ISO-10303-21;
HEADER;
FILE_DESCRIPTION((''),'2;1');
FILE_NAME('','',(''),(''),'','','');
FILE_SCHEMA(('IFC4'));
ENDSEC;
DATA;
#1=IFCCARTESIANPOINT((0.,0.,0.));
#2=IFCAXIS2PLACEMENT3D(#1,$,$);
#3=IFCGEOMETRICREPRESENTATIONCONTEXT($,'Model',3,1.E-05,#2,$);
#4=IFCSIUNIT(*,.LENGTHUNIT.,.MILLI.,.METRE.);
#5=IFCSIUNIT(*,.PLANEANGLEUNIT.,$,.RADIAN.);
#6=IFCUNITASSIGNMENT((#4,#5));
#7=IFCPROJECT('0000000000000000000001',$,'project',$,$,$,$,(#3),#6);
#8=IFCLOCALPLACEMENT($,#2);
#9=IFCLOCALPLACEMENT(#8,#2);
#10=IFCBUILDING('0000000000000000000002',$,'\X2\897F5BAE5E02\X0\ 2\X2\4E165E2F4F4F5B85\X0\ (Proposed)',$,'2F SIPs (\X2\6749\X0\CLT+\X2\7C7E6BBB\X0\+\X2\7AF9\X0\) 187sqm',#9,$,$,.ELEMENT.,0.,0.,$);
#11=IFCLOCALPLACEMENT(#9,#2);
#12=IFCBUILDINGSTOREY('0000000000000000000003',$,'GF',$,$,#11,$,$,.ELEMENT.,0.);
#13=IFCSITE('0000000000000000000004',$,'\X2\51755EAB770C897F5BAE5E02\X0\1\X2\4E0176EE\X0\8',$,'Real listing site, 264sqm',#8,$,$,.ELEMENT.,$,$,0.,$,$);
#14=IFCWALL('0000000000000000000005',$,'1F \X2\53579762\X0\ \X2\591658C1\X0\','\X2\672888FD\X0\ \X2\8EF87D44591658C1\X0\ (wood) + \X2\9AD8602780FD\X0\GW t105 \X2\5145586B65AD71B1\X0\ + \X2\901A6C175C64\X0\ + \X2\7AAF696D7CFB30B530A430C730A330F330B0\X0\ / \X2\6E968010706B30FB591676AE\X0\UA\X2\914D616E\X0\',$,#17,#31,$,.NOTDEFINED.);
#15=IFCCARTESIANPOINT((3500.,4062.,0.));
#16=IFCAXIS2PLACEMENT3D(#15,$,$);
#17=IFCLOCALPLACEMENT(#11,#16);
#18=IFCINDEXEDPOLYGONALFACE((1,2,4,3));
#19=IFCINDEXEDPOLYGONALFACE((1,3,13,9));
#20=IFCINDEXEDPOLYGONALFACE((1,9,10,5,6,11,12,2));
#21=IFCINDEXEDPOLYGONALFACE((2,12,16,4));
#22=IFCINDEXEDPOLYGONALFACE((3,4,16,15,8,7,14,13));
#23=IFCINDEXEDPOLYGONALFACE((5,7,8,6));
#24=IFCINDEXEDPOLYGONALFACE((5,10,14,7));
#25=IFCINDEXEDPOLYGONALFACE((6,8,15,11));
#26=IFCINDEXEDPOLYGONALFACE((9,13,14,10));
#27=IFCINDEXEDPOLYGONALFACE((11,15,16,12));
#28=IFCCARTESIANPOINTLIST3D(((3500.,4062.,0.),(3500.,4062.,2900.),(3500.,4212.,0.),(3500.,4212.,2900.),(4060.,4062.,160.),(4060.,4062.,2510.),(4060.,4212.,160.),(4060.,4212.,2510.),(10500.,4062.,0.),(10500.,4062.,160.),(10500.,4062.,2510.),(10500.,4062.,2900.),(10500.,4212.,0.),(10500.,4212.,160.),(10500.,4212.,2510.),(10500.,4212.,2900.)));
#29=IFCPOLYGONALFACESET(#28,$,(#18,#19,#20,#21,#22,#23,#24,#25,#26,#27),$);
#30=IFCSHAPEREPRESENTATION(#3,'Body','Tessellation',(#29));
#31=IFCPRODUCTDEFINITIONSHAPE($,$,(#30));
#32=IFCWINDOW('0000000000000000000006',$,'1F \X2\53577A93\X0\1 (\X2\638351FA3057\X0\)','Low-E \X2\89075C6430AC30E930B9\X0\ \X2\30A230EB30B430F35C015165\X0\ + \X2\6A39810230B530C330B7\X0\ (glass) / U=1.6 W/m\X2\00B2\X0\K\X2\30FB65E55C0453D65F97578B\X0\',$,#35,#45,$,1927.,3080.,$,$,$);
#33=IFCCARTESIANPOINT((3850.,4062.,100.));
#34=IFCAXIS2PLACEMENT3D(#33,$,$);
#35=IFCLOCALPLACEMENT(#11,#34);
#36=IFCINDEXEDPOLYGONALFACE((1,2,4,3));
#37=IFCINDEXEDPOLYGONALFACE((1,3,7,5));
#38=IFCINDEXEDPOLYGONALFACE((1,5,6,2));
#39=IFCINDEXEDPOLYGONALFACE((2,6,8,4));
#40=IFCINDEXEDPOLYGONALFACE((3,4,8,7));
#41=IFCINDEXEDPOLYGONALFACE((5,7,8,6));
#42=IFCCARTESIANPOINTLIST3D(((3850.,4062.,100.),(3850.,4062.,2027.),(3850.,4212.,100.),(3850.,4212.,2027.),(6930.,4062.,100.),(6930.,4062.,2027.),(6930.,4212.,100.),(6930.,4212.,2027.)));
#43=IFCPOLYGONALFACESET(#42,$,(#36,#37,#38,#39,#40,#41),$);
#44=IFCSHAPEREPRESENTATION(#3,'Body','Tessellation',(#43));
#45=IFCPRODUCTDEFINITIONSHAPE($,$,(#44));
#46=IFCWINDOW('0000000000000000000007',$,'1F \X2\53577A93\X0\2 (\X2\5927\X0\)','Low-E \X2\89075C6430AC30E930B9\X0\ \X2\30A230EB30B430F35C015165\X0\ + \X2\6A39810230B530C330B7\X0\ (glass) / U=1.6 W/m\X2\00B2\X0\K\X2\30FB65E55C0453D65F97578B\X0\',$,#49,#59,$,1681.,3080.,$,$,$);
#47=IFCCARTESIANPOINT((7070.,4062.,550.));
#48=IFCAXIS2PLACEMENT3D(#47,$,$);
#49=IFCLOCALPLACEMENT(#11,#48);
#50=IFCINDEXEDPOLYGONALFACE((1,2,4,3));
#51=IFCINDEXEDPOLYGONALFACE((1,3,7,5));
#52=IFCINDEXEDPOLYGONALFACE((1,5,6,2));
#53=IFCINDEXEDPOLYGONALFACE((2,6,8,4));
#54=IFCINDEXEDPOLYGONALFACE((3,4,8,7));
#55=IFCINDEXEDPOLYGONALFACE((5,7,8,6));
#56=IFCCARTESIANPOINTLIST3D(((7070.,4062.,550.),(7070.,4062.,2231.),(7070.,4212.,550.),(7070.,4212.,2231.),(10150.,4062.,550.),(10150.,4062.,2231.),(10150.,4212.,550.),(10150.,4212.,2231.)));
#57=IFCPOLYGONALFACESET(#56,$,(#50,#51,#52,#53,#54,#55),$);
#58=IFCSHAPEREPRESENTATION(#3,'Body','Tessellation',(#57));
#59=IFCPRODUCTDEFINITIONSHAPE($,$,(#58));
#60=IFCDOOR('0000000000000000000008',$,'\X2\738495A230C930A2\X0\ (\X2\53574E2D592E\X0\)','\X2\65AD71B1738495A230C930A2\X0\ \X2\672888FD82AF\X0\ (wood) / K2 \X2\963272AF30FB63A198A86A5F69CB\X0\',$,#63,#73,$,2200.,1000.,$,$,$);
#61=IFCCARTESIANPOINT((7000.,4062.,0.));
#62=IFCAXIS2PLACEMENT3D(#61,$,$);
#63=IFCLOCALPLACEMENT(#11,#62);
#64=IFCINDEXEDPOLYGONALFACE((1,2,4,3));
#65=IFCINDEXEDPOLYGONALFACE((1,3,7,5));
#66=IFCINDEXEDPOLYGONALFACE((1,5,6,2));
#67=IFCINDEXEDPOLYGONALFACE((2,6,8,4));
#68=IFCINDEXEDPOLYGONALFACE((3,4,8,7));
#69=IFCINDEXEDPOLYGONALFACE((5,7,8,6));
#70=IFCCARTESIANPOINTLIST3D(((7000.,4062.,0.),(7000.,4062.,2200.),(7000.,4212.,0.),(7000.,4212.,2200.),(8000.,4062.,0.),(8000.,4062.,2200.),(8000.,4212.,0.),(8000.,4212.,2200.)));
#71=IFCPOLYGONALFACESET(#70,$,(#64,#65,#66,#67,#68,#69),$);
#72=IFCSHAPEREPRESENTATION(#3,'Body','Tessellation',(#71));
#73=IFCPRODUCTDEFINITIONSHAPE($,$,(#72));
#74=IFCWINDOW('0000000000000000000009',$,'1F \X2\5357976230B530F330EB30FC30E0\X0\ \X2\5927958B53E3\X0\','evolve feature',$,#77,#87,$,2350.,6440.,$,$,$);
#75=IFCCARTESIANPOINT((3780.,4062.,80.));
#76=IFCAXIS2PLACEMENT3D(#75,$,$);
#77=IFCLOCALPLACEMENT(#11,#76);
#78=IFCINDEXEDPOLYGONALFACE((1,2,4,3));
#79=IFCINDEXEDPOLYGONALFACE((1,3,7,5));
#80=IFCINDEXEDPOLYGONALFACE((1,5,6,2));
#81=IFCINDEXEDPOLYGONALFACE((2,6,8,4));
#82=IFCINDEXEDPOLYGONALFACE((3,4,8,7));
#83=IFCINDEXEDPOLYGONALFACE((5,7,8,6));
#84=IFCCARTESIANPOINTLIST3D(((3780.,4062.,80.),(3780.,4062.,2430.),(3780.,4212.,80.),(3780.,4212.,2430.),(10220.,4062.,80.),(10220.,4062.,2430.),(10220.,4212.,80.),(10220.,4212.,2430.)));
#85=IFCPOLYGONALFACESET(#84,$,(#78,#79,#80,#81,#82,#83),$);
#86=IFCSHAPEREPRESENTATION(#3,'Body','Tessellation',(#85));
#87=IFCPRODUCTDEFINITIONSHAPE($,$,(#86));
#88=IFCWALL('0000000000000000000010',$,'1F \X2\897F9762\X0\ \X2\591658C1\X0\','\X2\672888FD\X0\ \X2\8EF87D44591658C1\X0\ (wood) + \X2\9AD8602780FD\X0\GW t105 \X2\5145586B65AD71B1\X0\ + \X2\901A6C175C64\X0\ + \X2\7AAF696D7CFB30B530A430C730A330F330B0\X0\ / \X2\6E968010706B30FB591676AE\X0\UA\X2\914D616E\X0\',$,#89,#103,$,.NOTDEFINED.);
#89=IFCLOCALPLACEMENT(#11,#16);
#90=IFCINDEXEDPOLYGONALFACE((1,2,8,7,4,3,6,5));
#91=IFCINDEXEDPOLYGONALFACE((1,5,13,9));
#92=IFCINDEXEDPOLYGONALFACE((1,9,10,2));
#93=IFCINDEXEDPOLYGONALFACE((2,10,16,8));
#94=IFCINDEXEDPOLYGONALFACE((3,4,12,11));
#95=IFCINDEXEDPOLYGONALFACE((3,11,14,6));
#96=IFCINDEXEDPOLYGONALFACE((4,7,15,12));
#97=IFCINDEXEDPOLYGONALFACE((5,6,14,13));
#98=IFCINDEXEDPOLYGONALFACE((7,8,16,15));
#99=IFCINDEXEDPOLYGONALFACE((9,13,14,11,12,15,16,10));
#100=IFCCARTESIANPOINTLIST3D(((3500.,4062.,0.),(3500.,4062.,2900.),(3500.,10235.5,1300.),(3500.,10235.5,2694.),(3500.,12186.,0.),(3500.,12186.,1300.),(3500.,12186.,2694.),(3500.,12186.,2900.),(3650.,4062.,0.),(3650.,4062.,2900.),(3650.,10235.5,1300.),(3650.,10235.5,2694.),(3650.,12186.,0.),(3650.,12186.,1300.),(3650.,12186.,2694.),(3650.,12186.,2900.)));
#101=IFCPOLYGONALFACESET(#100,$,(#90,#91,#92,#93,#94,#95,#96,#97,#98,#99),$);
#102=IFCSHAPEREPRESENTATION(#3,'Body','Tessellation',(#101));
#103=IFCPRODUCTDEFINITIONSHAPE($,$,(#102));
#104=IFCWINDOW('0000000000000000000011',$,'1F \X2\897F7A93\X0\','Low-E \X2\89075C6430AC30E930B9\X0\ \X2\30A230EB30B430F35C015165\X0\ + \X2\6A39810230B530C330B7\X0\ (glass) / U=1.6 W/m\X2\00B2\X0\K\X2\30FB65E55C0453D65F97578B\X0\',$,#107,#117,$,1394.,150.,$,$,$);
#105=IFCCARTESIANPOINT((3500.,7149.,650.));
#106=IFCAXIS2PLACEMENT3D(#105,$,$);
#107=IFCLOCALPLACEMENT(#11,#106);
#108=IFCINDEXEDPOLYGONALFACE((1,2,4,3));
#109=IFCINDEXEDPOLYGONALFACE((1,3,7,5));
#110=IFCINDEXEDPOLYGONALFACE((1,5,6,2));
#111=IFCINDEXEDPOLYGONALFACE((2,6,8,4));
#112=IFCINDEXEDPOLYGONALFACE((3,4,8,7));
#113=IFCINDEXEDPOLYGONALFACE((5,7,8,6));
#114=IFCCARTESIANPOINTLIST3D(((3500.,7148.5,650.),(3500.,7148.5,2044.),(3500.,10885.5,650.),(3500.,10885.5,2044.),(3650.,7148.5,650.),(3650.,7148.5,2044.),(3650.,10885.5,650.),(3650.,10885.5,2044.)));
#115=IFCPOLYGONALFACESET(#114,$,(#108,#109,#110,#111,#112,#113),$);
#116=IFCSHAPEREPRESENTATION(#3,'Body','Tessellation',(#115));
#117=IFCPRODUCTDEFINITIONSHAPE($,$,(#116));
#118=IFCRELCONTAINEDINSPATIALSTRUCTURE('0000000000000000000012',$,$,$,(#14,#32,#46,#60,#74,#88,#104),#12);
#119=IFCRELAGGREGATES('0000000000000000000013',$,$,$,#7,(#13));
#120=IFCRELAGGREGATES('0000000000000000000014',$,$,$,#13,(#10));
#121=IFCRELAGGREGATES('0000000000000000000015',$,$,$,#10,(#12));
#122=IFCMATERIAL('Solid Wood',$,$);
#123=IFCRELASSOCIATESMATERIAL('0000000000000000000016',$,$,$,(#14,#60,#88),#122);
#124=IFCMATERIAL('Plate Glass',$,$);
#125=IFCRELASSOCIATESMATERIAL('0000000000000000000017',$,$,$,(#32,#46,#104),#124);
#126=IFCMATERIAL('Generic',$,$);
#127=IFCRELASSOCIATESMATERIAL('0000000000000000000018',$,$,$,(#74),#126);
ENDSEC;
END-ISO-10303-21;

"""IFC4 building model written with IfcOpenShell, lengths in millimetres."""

from ifc_helpers import new_model, si_unit, frame, frame_2d, origin, place, context, project, spatial, rectangle, extrude, material, element, fill, save


model = new_model("IFC4")

# Units and contexts
model_context = context("Model", 3, precision=1e-05, world=origin())
ifc_project = project(units=[si_unit("LENGTHUNIT", "METRE", prefix="MILLI"), si_unit("PLANEANGLEUNIT", "RADIAN")], contexts=[model_context])

# Site, building, storey
site_placement = place(None, origin())
site = spatial("IfcSite", under=ifc_project, at=site_placement, Name="兵庫県西宮市1丁目8", ObjectType="Real listing site, 264sqm", CompositionType="ELEMENT", RefElevation=0.0)
building_placement = place(site_placement, origin())
building = spatial("IfcBuilding", under=site, at=building_placement, Name="西宮市 2世帯住宅 (Proposed)", ObjectType="2F SIPs (杉CLT+籾殻+竹) 187sqm", CompositionType="ELEMENT", ElevationOfRefHeight=0.0, ElevationOfTerrain=0.0)
storey_placement = place(building_placement, origin())
storey = spatial("IfcBuildingStorey", under=building, at=storey_placement, Name="GF", CompositionType="ELEMENT", Elevation=0.0)

# Shared definitions
ifc_material_1 = material(Name="Solid Wood")
ifc_material_2 = material(Name="Generic")

# Wall, openings, windows, door
wall_1_placement = place(storey_placement, frame((3500.0, 4062.0, 0.0)))
wall_1 = element("IfcWall", 1, at=wall_1_placement, inside=storey, material=ifc_material_1, Name="1F 南面 外壁", Description="木製 軸組外壁 (wood) + 高性能GW t105 充填断熱 + 通気層 + 窯業系サイディング / 準耐火・外皮UA配慮", PredefinedType="NOTDEFINED", context=model_context, shape_type="SweptSolid", body=[
    extrude(rectangle(XDim=7000.0, YDim=150.0, at=frame_2d((3500.0, 75.0))), frame((3500.0, 4062.0, 0.0)), (0.0, 0.0, 1.0), 2900.0),
])
opening_1_placement = place(storey_placement, frame((3850.0, 4062.0, 100.0)))
opening_1 = element("IfcOpeningElement", 2, at=opening_1_placement, cuts=wall_1, PredefinedType="NOTDEFINED", context=model_context, shape_type="SweptSolid", body=[
    extrude(rectangle(XDim=3080.0, YDim=150.0, at=frame_2d((1540.0, 75.0))), frame((3850.0, 4062.0, 100.0)), (0.0, 0.0, 1.0), 1927.0),
])
opening_2_placement = place(storey_placement, frame((7070.0, 4062.0, 550.0)))
opening_2 = element("IfcOpeningElement", 3, at=opening_2_placement, cuts=wall_1, PredefinedType="NOTDEFINED", context=model_context, shape_type="SweptSolid", body=[
    extrude(rectangle(XDim=3080.0, YDim=150.0, at=frame_2d((1540.0, 75.0))), frame((7070.0, 4062.0, 550.0)), (0.0, 0.0, 1.0), 1681.0),
])
opening_3_placement = place(storey_placement, frame((7000.0, 4062.0, 0.0)))
opening_3 = element("IfcOpeningElement", 4, at=opening_3_placement, cuts=wall_1, PredefinedType="NOTDEFINED", context=model_context, shape_type="SweptSolid", body=[
    extrude(rectangle(XDim=1000.0, YDim=150.0, at=frame_2d((500.0, 75.0))), frame((7000.0, 4062.0, 0.0)), (0.0, 0.0, 1.0), 2200.0),
])
opening_4_placement = place(storey_placement, frame((3780.0, 4062.0, 80.0)))
opening_4 = element("IfcOpeningElement", 5, at=opening_4_placement, cuts=wall_1, PredefinedType="NOTDEFINED", context=model_context, shape_type="SweptSolid", body=[
    extrude(rectangle(XDim=6440.0, YDim=150.0, at=frame_2d((3220.0, 75.0))), frame((3780.0, 4062.0, 80.0)), (0.0, 0.0, 1.0), 2350.0),
])
ifc_material_3 = material(Name="Plate Glass")
window_1_placement = place(storey_placement, frame((3850.0, 4062.0, 100.0)))
window_1 = element("IfcWindow", 6, at=window_1_placement, inside=storey, material=ifc_material_3, Name="1F 南窓1 (掃出し)", Description="Low-E 複層ガラス アルゴン封入 + 樹脂サッシ (glass) / U=1.6 W/m²K・日射取得型", OverallHeight=1927.0, OverallWidth=3080.0, context=model_context, shape_type="SweptSolid", body=[
    extrude(rectangle(XDim=3080.0, YDim=150.0, at=frame_2d((1540.0, 75.0))), frame((3850.0, 4062.0, 100.0)), (0.0, 0.0, 1.0), 1927.0),
])
fill(opening_1, window_1)
window_2_placement = place(storey_placement, frame((7070.0, 4062.0, 550.0)))
window_2 = element("IfcWindow", 7, at=window_2_placement, inside=storey, material=ifc_material_3, Name="1F 南窓2 (大)", Description="Low-E 複層ガラス アルゴン封入 + 樹脂サッシ (glass) / U=1.6 W/m²K・日射取得型", OverallHeight=1681.0, OverallWidth=3080.0, context=model_context, shape_type="SweptSolid", body=[
    extrude(rectangle(XDim=3080.0, YDim=150.0, at=frame_2d((1540.0, 75.0))), frame((7070.0, 4062.0, 550.0)), (0.0, 0.0, 1.0), 1681.0),
])
fill(opening_2, window_2)
door_placement = place(storey_placement, frame((7000.0, 4062.0, 0.0)))
door = element("IfcDoor", 8, at=door_placement, inside=storey, material=ifc_material_1, Name="玄関ドア (南中央)", Description="断熱玄関ドア 木製芯 (wood) / K2 防犯・採風機構", OverallHeight=2200.0, OverallWidth=1000.0, context=model_context, shape_type="SweptSolid", body=[
    extrude(rectangle(XDim=1000.0, YDim=150.0, at=frame_2d((500.0, 75.0))), frame((7000.0, 4062.0, 0.0)), (0.0, 0.0, 1.0), 2200.0),
])
fill(opening_3, door)
window_3_placement = place(storey_placement, frame((3780.0, 4062.0, 80.0)))
window_3 = element("IfcWindow", 9, at=window_3_placement, inside=storey, material=ifc_material_2, Name="1F 南面サンルーム 大開口", Description="evolve feature", OverallHeight=2350.0, OverallWidth=6440.0, context=model_context, shape_type="SweptSolid", body=[
    extrude(rectangle(XDim=6440.0, YDim=150.0, at=frame_2d((3220.0, 75.0))), frame((3780.0, 4062.0, 80.0)), (0.0, 0.0, 1.0), 2350.0),
])
fill(opening_4, window_3)

# Wall, opening, window
wall_2_placement = place(storey_placement, frame((3500.0, 4062.0, 0.0)))
wall_2 = element("IfcWall", 10, at=wall_2_placement, inside=storey, material=ifc_material_1, Name="1F 西面 外壁", Description="木製 軸組外壁 (wood) + 高性能GW t105 充填断熱 + 通気層 + 窯業系サイディング / 準耐火・外皮UA配慮", PredefinedType="NOTDEFINED", context=model_context, shape_type="SweptSolid", body=[
    extrude(rectangle(XDim=150.0, YDim=8124.0, at=frame_2d((75.0, 4062.0))), frame((3500.0, 4062.0, 0.0)), (0.0, 0.0, 1.0), 2900.0),
])
opening_5_placement = place(storey_placement, frame((3500.0, 7149.0, 650.0)))
opening_5 = element("IfcOpeningElement", 11, at=opening_5_placement, cuts=wall_2, PredefinedType="NOTDEFINED", context=model_context, shape_type="SweptSolid", body=[
    extrude(rectangle(XDim=150.0, YDim=3737.0, at=frame_2d((75.0, 1868.0))), frame((3500.0, 7149.0, 650.0)), (0.0, 0.0, 1.0), 1394.0),
])
window_4_placement = place(storey_placement, frame((3500.0, 7149.0, 650.0)))
window_4 = element("IfcWindow", 12, at=window_4_placement, inside=storey, material=ifc_material_3, Name="1F 西窓", Description="Low-E 複層ガラス アルゴン封入 + 樹脂サッシ (glass) / U=1.6 W/m²K・日射取得型", OverallHeight=1394.0, OverallWidth=150.0, context=model_context, shape_type="SweptSolid", body=[
    extrude(rectangle(XDim=150.0, YDim=3737.0, at=frame_2d((75.0, 1868.0))), frame((3500.0, 7149.0, 650.0)), (0.0, 0.0, 1.0), 1394.0),
])
fill(opening_5, window_4)

save(model, "model.ifc")
